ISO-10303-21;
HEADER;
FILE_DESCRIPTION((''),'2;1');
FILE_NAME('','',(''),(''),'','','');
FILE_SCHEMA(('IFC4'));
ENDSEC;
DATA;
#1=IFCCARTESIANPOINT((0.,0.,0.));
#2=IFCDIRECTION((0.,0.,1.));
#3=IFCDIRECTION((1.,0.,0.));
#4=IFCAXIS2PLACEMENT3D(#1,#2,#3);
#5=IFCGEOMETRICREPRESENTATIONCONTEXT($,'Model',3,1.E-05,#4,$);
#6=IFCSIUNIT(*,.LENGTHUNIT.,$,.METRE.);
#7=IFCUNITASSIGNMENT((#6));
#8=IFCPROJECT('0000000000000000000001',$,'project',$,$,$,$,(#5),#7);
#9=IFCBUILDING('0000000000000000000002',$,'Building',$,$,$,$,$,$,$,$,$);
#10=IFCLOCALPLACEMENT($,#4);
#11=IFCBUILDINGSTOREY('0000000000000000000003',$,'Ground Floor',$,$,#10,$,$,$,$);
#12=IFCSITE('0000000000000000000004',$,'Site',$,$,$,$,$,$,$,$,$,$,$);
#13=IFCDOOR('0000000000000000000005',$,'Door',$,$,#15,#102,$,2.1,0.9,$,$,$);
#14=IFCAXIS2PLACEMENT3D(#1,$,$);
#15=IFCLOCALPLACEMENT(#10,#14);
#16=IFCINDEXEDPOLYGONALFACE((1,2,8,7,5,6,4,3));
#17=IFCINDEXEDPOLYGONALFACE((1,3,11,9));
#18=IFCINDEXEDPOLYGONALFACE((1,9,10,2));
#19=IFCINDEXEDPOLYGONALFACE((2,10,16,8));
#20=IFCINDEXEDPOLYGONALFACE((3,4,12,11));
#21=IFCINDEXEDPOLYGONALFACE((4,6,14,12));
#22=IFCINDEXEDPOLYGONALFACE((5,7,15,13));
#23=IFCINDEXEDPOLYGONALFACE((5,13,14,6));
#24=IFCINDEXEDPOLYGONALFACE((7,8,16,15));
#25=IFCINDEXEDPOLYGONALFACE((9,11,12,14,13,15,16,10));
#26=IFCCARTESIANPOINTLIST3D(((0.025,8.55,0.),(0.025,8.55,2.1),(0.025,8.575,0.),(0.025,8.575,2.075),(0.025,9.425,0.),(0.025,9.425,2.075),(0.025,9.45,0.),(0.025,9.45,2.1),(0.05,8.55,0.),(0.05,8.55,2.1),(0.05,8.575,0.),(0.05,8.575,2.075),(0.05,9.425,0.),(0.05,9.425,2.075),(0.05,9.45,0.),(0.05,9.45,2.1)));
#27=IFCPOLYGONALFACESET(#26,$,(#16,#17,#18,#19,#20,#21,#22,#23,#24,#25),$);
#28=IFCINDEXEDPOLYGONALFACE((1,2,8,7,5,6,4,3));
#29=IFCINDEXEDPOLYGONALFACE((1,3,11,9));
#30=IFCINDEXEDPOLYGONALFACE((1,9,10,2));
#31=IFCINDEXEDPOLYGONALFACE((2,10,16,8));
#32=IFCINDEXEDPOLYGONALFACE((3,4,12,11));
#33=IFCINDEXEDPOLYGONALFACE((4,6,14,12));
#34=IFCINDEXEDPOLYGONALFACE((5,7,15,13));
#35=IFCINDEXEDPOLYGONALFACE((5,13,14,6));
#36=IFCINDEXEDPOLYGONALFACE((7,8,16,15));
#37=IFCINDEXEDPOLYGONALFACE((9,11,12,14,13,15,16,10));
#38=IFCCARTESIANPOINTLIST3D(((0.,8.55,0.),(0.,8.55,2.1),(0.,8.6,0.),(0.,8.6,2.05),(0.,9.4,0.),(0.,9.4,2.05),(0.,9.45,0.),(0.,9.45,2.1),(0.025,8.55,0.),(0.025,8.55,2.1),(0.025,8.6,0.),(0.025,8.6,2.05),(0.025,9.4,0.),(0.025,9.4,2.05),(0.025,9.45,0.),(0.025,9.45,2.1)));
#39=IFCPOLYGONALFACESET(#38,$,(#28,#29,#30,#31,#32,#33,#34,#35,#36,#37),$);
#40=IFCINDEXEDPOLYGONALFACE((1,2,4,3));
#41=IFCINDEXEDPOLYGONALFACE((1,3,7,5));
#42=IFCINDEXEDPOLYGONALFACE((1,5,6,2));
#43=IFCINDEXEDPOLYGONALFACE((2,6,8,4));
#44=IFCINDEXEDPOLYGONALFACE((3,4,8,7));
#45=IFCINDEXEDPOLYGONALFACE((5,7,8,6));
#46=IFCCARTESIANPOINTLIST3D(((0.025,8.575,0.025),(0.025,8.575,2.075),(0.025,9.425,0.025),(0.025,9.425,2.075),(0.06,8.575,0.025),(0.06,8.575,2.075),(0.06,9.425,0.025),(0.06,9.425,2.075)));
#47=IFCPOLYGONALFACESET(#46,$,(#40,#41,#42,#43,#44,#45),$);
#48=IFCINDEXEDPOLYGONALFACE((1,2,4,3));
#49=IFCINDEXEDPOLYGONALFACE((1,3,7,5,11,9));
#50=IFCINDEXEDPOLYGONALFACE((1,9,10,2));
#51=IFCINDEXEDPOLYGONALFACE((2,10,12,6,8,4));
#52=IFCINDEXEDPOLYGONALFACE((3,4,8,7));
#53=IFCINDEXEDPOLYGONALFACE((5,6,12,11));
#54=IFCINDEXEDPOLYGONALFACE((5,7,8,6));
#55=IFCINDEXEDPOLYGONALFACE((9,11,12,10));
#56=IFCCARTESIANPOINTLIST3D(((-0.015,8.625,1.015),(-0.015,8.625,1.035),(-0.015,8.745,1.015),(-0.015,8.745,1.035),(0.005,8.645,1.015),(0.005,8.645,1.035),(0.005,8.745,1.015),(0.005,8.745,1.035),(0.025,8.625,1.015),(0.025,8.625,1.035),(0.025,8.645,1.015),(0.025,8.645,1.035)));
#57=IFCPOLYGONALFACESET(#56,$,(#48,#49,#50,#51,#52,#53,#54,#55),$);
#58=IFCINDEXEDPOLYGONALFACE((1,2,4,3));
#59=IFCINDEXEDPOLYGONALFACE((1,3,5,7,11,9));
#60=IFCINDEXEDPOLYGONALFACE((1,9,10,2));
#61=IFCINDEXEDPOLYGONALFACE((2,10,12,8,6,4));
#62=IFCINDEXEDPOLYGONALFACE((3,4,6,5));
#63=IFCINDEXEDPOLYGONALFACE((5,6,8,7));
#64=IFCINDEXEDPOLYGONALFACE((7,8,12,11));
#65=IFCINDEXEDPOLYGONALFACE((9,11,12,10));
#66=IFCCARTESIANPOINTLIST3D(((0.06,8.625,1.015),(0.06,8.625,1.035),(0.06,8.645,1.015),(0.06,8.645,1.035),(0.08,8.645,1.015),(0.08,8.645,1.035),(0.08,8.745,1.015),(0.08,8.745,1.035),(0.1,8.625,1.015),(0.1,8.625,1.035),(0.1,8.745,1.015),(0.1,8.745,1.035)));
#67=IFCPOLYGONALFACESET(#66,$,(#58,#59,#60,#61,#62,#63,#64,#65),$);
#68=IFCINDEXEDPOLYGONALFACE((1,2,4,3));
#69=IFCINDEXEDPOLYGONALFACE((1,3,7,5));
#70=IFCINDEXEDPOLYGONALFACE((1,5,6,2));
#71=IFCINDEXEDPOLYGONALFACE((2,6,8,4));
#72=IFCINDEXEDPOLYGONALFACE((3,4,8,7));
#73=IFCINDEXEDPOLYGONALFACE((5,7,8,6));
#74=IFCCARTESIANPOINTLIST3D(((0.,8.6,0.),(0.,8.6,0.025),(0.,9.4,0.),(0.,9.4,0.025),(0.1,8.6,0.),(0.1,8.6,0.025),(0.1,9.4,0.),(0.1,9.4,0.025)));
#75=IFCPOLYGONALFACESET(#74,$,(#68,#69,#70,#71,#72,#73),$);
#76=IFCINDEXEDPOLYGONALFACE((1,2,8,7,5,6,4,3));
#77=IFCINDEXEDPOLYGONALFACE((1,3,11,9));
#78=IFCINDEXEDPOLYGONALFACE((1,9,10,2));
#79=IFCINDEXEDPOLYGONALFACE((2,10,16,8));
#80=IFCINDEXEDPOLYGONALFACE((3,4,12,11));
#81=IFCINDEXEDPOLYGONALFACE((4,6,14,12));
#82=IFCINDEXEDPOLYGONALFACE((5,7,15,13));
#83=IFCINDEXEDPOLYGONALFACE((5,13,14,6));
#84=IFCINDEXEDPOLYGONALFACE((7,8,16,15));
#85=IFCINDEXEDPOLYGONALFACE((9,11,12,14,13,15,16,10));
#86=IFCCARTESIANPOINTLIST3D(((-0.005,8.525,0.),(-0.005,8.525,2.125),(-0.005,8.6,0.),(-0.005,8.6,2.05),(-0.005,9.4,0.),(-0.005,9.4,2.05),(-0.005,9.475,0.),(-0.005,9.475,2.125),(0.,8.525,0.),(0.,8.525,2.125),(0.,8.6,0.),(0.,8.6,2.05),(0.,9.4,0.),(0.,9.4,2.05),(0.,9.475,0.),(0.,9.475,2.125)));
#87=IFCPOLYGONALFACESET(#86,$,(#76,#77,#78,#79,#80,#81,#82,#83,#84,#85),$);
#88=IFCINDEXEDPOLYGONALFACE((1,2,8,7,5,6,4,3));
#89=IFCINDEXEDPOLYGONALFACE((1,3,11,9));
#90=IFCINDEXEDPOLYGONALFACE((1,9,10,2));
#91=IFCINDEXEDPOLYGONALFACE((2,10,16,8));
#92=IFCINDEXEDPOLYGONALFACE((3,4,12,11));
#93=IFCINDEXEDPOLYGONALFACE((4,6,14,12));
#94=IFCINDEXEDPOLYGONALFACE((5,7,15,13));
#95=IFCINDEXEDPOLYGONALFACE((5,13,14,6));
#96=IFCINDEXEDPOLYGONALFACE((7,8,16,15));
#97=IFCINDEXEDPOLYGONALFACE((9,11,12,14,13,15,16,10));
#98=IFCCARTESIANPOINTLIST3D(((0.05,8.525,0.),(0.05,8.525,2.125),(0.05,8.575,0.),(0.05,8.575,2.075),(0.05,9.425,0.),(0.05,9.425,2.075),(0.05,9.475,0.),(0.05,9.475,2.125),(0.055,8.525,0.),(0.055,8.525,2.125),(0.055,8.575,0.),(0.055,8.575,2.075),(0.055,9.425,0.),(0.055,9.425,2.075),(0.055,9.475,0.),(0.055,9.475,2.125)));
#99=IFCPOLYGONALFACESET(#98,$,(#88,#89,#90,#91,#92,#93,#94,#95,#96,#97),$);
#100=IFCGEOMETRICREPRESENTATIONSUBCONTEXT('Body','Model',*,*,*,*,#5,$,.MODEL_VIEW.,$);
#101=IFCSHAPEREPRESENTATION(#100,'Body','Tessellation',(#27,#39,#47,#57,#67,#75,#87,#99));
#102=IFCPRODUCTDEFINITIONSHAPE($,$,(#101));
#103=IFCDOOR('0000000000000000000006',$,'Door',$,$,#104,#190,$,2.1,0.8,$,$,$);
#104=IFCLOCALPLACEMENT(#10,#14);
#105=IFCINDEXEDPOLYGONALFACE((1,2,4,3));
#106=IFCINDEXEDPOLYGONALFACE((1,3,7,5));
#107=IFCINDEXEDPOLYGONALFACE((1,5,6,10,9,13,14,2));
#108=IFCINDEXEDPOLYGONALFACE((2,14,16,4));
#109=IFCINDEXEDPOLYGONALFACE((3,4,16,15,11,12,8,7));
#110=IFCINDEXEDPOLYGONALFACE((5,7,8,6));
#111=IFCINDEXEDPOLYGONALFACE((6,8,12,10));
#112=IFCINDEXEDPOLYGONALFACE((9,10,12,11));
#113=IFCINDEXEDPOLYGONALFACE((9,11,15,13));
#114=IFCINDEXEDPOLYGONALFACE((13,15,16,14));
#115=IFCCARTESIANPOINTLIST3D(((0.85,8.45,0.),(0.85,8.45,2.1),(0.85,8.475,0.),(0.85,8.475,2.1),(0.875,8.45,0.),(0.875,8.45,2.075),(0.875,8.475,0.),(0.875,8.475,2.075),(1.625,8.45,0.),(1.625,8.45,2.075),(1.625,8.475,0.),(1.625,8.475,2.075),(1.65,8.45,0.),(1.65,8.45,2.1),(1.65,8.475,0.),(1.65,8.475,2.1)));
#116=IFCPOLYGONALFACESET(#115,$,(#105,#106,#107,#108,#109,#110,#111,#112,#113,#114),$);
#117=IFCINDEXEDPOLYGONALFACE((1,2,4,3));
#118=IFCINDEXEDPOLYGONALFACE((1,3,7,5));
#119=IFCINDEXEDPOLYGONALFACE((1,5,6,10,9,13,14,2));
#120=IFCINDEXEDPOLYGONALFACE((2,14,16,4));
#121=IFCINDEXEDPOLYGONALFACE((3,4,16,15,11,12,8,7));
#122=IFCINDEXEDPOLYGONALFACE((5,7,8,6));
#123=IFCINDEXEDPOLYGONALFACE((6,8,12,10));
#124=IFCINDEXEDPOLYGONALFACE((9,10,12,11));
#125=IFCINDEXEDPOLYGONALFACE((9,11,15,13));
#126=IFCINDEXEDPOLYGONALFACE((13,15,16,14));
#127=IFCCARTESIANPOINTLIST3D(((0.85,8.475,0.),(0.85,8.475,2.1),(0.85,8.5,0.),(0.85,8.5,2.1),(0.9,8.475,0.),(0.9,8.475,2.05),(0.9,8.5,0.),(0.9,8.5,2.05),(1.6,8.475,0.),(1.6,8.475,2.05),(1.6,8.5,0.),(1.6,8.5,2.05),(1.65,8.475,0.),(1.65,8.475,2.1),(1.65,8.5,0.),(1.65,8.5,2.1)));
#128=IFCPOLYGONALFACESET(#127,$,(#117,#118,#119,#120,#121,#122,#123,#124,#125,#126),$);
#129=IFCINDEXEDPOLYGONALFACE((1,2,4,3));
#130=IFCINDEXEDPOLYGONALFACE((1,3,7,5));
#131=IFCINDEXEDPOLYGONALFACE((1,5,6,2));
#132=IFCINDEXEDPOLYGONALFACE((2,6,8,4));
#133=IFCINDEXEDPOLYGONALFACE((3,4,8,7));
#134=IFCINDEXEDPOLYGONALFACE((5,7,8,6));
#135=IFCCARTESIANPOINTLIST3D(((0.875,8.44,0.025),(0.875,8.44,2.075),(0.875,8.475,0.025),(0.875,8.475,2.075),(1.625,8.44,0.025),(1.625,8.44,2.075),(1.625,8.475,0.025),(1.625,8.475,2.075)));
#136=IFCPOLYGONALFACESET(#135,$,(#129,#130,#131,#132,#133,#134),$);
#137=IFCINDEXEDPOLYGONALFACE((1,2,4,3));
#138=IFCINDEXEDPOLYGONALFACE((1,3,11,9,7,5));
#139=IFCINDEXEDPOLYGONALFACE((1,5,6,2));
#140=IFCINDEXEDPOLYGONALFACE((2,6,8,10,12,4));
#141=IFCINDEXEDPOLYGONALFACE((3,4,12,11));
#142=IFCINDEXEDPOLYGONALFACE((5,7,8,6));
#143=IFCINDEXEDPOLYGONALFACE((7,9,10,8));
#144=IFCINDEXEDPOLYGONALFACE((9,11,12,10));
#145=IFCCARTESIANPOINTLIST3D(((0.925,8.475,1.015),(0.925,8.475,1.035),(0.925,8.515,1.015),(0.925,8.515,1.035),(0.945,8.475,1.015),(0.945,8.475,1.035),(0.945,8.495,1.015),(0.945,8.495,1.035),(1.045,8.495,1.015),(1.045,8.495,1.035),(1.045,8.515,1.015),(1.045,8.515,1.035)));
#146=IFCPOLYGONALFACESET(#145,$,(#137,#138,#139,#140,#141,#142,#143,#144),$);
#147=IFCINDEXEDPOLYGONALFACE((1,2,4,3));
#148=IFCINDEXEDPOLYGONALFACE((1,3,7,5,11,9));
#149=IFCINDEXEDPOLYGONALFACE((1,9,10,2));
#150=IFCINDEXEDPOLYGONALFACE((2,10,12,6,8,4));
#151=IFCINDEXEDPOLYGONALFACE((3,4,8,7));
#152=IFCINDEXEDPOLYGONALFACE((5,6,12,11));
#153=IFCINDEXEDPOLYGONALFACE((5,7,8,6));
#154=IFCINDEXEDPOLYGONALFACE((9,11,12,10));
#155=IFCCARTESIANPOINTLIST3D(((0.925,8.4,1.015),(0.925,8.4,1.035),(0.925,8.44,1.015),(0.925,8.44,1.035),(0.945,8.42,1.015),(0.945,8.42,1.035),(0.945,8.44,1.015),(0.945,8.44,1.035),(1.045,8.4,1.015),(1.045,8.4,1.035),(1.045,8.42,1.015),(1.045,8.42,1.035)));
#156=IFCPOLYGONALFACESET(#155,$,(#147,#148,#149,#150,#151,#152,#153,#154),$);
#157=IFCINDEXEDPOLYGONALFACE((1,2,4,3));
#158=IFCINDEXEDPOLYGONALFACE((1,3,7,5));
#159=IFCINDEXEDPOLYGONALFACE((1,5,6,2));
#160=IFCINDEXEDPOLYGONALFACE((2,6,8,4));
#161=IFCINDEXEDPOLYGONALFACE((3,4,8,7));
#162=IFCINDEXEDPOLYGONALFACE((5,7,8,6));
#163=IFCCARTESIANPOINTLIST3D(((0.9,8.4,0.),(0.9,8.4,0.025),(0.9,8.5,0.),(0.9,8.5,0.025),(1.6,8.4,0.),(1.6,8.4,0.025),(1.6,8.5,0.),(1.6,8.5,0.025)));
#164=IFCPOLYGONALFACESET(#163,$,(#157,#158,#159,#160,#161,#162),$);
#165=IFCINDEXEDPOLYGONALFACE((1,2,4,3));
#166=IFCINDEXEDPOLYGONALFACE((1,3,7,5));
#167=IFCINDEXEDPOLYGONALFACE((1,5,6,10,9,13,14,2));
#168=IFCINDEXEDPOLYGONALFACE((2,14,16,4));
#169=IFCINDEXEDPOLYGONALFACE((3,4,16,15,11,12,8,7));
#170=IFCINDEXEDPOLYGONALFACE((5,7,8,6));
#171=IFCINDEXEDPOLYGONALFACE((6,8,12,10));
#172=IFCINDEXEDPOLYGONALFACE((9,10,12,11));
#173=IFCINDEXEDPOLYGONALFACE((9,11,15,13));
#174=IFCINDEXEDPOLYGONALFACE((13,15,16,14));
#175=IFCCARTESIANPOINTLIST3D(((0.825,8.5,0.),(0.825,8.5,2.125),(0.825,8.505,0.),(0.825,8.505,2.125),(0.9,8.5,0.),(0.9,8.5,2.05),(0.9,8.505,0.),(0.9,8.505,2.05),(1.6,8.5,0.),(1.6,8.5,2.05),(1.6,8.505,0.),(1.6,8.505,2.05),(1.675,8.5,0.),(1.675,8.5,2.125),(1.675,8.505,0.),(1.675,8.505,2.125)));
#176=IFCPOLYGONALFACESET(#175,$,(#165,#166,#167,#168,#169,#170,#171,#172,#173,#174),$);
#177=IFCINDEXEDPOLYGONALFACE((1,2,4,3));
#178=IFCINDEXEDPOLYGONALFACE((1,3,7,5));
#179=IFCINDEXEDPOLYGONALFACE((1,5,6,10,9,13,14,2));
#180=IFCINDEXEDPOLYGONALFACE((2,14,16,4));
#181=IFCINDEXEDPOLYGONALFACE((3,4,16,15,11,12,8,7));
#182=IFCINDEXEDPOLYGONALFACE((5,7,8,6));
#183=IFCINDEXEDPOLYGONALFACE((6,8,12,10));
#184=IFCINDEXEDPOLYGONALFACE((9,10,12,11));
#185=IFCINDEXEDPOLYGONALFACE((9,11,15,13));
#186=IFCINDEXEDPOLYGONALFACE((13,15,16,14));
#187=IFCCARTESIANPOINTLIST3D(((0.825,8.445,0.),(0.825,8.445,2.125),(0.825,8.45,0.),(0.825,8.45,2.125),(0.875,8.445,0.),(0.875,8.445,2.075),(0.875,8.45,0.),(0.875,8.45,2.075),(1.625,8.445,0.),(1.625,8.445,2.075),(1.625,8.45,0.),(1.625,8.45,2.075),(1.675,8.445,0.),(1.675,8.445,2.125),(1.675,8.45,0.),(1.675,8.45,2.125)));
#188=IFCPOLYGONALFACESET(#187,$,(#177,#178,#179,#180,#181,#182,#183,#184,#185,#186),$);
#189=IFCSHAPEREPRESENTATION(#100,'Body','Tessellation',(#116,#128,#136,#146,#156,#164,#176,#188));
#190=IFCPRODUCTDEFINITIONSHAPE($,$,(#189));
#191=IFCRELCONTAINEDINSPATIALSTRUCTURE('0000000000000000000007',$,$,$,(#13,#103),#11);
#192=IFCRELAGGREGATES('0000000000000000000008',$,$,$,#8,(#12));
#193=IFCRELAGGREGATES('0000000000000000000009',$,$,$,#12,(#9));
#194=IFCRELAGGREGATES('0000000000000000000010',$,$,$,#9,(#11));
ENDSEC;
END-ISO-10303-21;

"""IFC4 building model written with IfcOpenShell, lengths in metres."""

from ifc_helpers import new_model, si_unit, frame, origin_with_axes, place, context, subcontext, project, spatial, line, indexed_curve, outline, extrude, element, save


model = new_model("IFC4")

# Units and contexts
model_context = context("Model", 3, precision=1e-05, world=origin_with_axes())
body_context = subcontext(model_context, "Body", "Model", "MODEL_VIEW")
ifc_project = project(units=[si_unit("LENGTHUNIT", "METRE")], contexts=[model_context])

# Site, building, storey
site = spatial("IfcSite", under=ifc_project, Name="Site")
building = spatial("IfcBuilding", under=site, Name="Building")
storey_placement = place(None, origin_with_axes())
storey = spatial("IfcBuildingStorey", under=building, at=storey_placement, Name="Ground Floor")

# Doors
door_1_placement = place(storey_placement, frame((0.0, 9.45, 0.0), z_axis=(0.0, 0.0, 1.0), x_axis=(0.0, -1.0, 0.0)))
element("IfcDoor", 1, at=door_1_placement, inside=storey, Name="Door", OverallHeight=2.1, OverallWidth=0.9, context=body_context, shape_type="SweptSolid", body=[
    extrude(outline(indexed_curve([(0.0, 0.0), (0.0, 2.1), (0.9, 2.1), (0.9, 0.0), (0.875, 0.0), (0.875, 2.075), (0.025, 2.075), (0.025, 0.0)], segments=[line(1, 2, 3, 4, 5, 6, 7, 8, 1)])), frame((0.0, 0.025, 0.0), z_axis=(0.0, -1.0, 0.0), x_axis=(1.0, 0.0, 0.0)), (0.0, 0.0, -1.0), 0.025),
    extrude(outline(indexed_curve([(0.0, 0.0), (0.0, 2.1), (0.9, 2.1), (0.9, 0.0), (0.85, 0.0), (0.85, 2.05), (0.05, 2.05), (0.05, 0.0)], segments=[line(1, 2, 3, 4, 5, 6, 7, 8, 1)])), frame((0.0, 0.0, 0.0), z_axis=(0.0, -1.0, 0.0), x_axis=(1.0, 0.0, 0.0)), (0.0, 0.0, -1.0), 0.025),
    extrude(outline(indexed_curve([(0.0, 0.0), (0.85, 0.0), (0.85, 0.035), (0.0, 0.035)], segments=[line(1, 2, 3, 4, 1)])), frame((0.025, 0.025, 0.025), z_axis=(0.0, 0.0, 1.0), x_axis=(1.0, 0.0, 0.0)), (0.0, 0.0, 1.0), 2.05),
    extrude(outline(indexed_curve([(0.0, 0.0), (0.0, -0.04), (-0.12, -0.04), (-0.12, -0.02), (-0.02, -0.02), (-0.02, 0.0)], segments=[line(1, 2, 3, 4, 5, 6, 1)])), frame((0.825, 0.025, 1.015), z_axis=(0.0, 0.0, 1.0), x_axis=(1.0, 0.0, 0.0)), (0.0, 0.0, 1.0), 0.02),
    extrude(outline(indexed_curve([(0.0, 0.0), (0.0, 0.04), (-0.12, 0.04), (-0.12, 0.02), (-0.02, 0.02), (-0.02, 0.0)], segments=[line(1, 2, 3, 4, 5, 6, 1)])), frame((0.825, 0.06, 1.015), z_axis=(0.0, 0.0, 1.0), x_axis=(1.0, 0.0, 0.0)), (0.0, 0.0, 1.0), 0.02),
    extrude(outline(indexed_curve([(0.0, 0.0), (0.8, 0.0), (0.8, 0.1), (0.0, 0.1)], segments=[line(1, 2, 3, 4, 1)])), frame((0.05, 0.0, 0.0), z_axis=(0.0, 0.0, 1.0), x_axis=(1.0, 0.0, 0.0)), (0.0, 0.0, 1.0), 0.025),
    extrude(outline(indexed_curve([(0.0, 0.0), (0.0, 2.125), (0.95, 2.125), (0.95, 0.0), (0.875, 0.0), (0.875, 2.05), (0.075, 2.05), (0.075, 0.0)], segments=[line(1, 2, 3, 4, 5, 6, 7, 8, 1)])), frame((-0.025, -0.005, 0.0), z_axis=(0.0, -1.0, 0.0), x_axis=(1.0, 0.0, 0.0)), (0.0, 0.0, -1.0), 0.005),
    extrude(outline(indexed_curve([(0.0, 0.0), (0.0, 2.125), (0.95, 2.125), (0.95, 0.0), (0.9, 0.0), (0.9, 2.075), (0.05, 2.075), (0.05, 0.0)], segments=[line(1, 2, 3, 4, 5, 6, 7, 8, 1)])), frame((-0.025, 0.05, 0.0), z_axis=(0.0, -1.0, 0.0), x_axis=(1.0, 0.0, 0.0)), (0.0, 0.0, -1.0), 0.005),
])
door_2_placement = place(storey_placement, frame((1.65, 8.5, 0.0), z_axis=(0.0, 0.0, 1.0), x_axis=(-1.0, 0.0, 0.0)))
element("IfcDoor", 2, at=door_2_placement, inside=storey, Name="Door", OverallHeight=2.1, OverallWidth=0.8, context=body_context, shape_type="SweptSolid", body=[
    extrude(outline(indexed_curve([(0.0, 0.0), (0.0, 2.1), (0.8, 2.1), (0.8, 0.0), (0.775, 0.0), (0.775, 2.075), (0.025, 2.075), (0.025, 0.0)], segments=[line(1, 2, 3, 4, 5, 6, 7, 8, 1)])), frame((0.0, 0.025, 0.0), z_axis=(0.0, -1.0, 0.0), x_axis=(1.0, 0.0, 0.0)), (0.0, 0.0, -1.0), 0.025),
    extrude(outline(indexed_curve([(0.0, 0.0), (0.0, 2.1), (0.8, 2.1), (0.8, 0.0), (0.75, 0.0), (0.75, 2.05), (0.05, 2.05), (0.05, 0.0)], segments=[line(1, 2, 3, 4, 5, 6, 7, 8, 1)])), frame((0.0, 0.0, 0.0), z_axis=(0.0, -1.0, 0.0), x_axis=(1.0, 0.0, 0.0)), (0.0, 0.0, -1.0), 0.025),
    extrude(outline(indexed_curve([(0.0, 0.0), (0.75, 0.0), (0.75, 0.035), (0.0, 0.035)], segments=[line(1, 2, 3, 4, 1)])), frame((0.025, 0.025, 0.025), z_axis=(0.0, 0.0, 1.0), x_axis=(1.0, 0.0, 0.0)), (0.0, 0.0, 1.0), 2.05),
    extrude(outline(indexed_curve([(0.0, 0.0), (0.0, -0.04), (-0.12, -0.04), (-0.12, -0.02), (-0.02, -0.02), (-0.02, 0.0)], segments=[line(1, 2, 3, 4, 5, 6, 1)])), frame((0.725, 0.025, 1.015), z_axis=(0.0, 0.0, 1.0), x_axis=(1.0, 0.0, 0.0)), (0.0, 0.0, 1.0), 0.02),
    extrude(outline(indexed_curve([(0.0, 0.0), (0.0, 0.04), (-0.12, 0.04), (-0.12, 0.02), (-0.02, 0.02), (-0.02, 0.0)], segments=[line(1, 2, 3, 4, 5, 6, 1)])), frame((0.725, 0.06, 1.015), z_axis=(0.0, 0.0, 1.0), x_axis=(1.0, 0.0, 0.0)), (0.0, 0.0, 1.0), 0.02),
    extrude(outline(indexed_curve([(0.0, 0.0), (0.7, 0.0), (0.7, 0.1), (0.0, 0.1)], segments=[line(1, 2, 3, 4, 1)])), frame((0.05, 0.0, 0.0), z_axis=(0.0, 0.0, 1.0), x_axis=(1.0, 0.0, 0.0)), (0.0, 0.0, 1.0), 0.025),
    extrude(outline(indexed_curve([(0.0, 0.0), (0.0, 2.125), (0.85, 2.125), (0.85, 0.0), (0.775, 0.0), (0.775, 2.05), (0.075, 2.05), (0.075, 0.0)], segments=[line(1, 2, 3, 4, 5, 6, 7, 8, 1)])), frame((-0.025, -0.005, 0.0), z_axis=(0.0, -1.0, 0.0), x_axis=(1.0, 0.0, 0.0)), (0.0, 0.0, -1.0), 0.005),
    extrude(outline(indexed_curve([(0.0, 0.0), (0.0, 2.125), (0.85, 2.125), (0.85, 0.0), (0.8, 0.0), (0.8, 2.075), (0.05, 2.075), (0.05, 0.0)], segments=[line(1, 2, 3, 4, 5, 6, 7, 8, 1)])), frame((-0.025, 0.05, 0.0), z_axis=(0.0, -1.0, 0.0), x_axis=(1.0, 0.0, 0.0)), (0.0, 0.0, -1.0), 0.005),
])

save(model, "model.ifc")
